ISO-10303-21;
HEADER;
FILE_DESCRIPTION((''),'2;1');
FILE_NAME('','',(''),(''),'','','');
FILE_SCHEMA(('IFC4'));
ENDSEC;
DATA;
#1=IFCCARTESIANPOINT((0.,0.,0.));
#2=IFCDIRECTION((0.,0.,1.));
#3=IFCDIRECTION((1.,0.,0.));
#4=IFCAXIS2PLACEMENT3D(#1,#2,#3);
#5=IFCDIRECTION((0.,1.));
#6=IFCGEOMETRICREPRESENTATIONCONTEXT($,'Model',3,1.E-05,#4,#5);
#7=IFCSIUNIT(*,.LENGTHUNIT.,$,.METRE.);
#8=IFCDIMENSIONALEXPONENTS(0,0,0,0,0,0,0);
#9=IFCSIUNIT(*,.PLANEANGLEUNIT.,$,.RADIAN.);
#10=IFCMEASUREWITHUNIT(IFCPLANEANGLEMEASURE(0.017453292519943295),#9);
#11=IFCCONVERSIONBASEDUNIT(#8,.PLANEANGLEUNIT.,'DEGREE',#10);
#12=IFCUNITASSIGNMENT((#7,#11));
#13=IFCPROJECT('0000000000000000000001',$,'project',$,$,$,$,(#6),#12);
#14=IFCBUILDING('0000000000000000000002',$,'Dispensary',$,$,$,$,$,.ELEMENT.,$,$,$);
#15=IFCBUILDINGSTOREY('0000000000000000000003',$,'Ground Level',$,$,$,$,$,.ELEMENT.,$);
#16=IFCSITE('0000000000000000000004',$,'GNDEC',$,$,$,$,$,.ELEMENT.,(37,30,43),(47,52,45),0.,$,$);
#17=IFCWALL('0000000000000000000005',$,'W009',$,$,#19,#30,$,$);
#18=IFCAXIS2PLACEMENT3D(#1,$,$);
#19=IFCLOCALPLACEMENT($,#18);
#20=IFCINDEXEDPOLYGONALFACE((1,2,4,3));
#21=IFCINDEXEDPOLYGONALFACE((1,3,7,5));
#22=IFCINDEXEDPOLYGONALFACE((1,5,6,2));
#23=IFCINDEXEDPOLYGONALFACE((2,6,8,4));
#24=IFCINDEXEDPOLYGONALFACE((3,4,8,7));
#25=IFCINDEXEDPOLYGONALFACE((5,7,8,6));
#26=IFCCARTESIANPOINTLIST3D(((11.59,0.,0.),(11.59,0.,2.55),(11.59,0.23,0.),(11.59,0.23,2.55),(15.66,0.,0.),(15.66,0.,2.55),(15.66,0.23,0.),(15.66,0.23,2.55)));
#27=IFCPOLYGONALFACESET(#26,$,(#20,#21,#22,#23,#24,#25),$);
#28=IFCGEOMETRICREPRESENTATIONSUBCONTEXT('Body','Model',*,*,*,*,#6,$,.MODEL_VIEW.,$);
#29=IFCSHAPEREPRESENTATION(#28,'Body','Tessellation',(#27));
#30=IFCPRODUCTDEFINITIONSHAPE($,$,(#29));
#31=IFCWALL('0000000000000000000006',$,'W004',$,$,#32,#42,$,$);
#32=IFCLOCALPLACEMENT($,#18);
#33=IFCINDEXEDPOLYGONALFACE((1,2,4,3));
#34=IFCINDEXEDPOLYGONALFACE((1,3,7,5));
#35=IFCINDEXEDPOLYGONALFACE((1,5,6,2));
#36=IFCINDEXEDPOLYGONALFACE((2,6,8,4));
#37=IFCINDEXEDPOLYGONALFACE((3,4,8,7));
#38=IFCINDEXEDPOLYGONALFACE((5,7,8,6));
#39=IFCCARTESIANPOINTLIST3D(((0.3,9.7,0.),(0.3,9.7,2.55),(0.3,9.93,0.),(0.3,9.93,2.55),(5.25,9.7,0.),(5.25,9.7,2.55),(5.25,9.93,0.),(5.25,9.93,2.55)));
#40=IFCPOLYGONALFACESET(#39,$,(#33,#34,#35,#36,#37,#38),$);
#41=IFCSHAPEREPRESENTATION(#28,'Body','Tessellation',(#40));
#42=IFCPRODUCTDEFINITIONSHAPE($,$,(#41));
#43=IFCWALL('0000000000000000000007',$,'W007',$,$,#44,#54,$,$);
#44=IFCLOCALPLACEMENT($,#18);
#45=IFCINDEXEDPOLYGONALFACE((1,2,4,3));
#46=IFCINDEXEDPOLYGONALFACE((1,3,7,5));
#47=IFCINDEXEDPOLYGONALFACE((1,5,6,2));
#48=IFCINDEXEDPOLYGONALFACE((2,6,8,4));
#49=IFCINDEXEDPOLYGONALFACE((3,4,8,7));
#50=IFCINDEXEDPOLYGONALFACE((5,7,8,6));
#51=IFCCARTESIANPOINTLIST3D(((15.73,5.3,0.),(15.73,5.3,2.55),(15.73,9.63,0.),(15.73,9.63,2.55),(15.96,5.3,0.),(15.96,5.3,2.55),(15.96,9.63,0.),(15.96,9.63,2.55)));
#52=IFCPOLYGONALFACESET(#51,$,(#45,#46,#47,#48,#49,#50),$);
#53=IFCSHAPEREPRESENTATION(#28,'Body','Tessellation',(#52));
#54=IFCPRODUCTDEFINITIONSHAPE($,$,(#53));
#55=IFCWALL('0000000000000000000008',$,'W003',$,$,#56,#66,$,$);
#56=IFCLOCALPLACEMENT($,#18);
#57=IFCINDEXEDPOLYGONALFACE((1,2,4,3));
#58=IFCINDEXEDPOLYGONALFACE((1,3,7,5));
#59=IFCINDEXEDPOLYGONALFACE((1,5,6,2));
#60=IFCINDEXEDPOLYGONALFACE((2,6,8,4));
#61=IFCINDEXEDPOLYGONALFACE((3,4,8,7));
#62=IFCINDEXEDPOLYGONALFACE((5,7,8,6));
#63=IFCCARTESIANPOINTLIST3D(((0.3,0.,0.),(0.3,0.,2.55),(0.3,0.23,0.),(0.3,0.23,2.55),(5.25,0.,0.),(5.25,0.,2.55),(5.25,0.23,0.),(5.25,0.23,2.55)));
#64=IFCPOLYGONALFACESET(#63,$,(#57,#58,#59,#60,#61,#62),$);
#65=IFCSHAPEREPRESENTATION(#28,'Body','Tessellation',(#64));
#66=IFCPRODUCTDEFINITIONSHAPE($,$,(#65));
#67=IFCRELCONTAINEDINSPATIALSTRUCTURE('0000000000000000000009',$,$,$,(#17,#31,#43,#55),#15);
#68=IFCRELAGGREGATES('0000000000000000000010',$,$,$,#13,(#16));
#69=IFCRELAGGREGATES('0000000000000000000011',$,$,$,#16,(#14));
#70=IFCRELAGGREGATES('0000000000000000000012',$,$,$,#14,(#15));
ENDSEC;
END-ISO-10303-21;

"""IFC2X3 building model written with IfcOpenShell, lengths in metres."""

from ifc_helpers import new_model, entity, si_unit, converted_unit, direction, frame, frame_2d, origin_with_axes, place, context, subcontext, project, spatial, rectangle, extrude, element, save


model = new_model("IFC2X3")

# Units and contexts
model_context = context("Model", 3, precision=1e-05, world=origin_with_axes(), true_north=direction((0.0, 1.0)))
body_context = subcontext(model_context, "Body", "Model", "MODEL_VIEW")
ifc_project = project(units=[si_unit("LENGTHUNIT", "METRE"), converted_unit("PLANEANGLEUNIT", "DEGREE", entity("IfcPlaneAngleMeasure", 0.017453292519943295), si_unit("PLANEANGLEUNIT", "RADIAN"), dimensions=[0, 0, 0, 0, 0, 0, 0])], contexts=[model_context])

# Site, building, storey
site = spatial("IfcSite", under=ifc_project, Name="GNDEC", CompositionType="ELEMENT", RefLatitude=(37, 30, 43), RefLongitude=(47, 52, 45), RefElevation=0.0)
building = spatial("IfcBuilding", under=site, Name="Dispensary", CompositionType="ELEMENT")
storey = spatial("IfcBuildingStorey", under=building, Name="Ground Level", CompositionType="ELEMENT")

# Shared definitions
placement = place(None, origin_with_axes())

# Walls
element("IfcWall", 1, at=placement, inside=storey, Name="W009", context=body_context, shape_type="SweptSolid", body=[
    extrude(rectangle(XDim=4.07, YDim=0.23, at=frame_2d((0.0, 0.0), x_axis=(1.0, 0.0))), frame((13.625, 0.115, 0.0), z_axis=(0.0, 0.0, 1.0), x_axis=(1.0, 0.0, 0.0)), (0.0, 0.0, 1.0), 2.55),
])
element("IfcWall", 2, at=placement, inside=storey, Name="W004", context=body_context, shape_type="SweptSolid", body=[
    extrude(rectangle(XDim=4.95, YDim=0.23, at=frame_2d((0.0, 0.0), x_axis=(-1.0, 0.0))), frame((2.775, 9.815, 0.0), z_axis=(0.0, 0.0, 1.0), x_axis=(1.0, 0.0, 0.0)), (0.0, 0.0, 1.0), 2.55),
])
element("IfcWall", 3, at=placement, inside=storey, Name="W007", context=body_context, shape_type="SweptSolid", body=[
    extrude(rectangle(XDim=4.33, YDim=0.23, at=frame_2d((0.0, 0.0), x_axis=(0.0, 1.0))), frame((15.845, 7.465, 0.0), z_axis=(0.0, 0.0, 1.0), x_axis=(1.0, 0.0, 0.0)), (0.0, 0.0, 1.0), 2.55),
])
element("IfcWall", 4, at=placement, inside=storey, Name="W003", context=body_context, shape_type="SweptSolid", body=[
    extrude(rectangle(XDim=4.95, YDim=0.23, at=frame_2d((0.0, 0.0), x_axis=(1.0, 0.0))), frame((2.775, 0.115, 0.0), z_axis=(0.0, 0.0, 1.0), x_axis=(1.0, 0.0, 0.0)), (0.0, 0.0, 1.0), 2.55),
])

save(model, "model.ifc")
